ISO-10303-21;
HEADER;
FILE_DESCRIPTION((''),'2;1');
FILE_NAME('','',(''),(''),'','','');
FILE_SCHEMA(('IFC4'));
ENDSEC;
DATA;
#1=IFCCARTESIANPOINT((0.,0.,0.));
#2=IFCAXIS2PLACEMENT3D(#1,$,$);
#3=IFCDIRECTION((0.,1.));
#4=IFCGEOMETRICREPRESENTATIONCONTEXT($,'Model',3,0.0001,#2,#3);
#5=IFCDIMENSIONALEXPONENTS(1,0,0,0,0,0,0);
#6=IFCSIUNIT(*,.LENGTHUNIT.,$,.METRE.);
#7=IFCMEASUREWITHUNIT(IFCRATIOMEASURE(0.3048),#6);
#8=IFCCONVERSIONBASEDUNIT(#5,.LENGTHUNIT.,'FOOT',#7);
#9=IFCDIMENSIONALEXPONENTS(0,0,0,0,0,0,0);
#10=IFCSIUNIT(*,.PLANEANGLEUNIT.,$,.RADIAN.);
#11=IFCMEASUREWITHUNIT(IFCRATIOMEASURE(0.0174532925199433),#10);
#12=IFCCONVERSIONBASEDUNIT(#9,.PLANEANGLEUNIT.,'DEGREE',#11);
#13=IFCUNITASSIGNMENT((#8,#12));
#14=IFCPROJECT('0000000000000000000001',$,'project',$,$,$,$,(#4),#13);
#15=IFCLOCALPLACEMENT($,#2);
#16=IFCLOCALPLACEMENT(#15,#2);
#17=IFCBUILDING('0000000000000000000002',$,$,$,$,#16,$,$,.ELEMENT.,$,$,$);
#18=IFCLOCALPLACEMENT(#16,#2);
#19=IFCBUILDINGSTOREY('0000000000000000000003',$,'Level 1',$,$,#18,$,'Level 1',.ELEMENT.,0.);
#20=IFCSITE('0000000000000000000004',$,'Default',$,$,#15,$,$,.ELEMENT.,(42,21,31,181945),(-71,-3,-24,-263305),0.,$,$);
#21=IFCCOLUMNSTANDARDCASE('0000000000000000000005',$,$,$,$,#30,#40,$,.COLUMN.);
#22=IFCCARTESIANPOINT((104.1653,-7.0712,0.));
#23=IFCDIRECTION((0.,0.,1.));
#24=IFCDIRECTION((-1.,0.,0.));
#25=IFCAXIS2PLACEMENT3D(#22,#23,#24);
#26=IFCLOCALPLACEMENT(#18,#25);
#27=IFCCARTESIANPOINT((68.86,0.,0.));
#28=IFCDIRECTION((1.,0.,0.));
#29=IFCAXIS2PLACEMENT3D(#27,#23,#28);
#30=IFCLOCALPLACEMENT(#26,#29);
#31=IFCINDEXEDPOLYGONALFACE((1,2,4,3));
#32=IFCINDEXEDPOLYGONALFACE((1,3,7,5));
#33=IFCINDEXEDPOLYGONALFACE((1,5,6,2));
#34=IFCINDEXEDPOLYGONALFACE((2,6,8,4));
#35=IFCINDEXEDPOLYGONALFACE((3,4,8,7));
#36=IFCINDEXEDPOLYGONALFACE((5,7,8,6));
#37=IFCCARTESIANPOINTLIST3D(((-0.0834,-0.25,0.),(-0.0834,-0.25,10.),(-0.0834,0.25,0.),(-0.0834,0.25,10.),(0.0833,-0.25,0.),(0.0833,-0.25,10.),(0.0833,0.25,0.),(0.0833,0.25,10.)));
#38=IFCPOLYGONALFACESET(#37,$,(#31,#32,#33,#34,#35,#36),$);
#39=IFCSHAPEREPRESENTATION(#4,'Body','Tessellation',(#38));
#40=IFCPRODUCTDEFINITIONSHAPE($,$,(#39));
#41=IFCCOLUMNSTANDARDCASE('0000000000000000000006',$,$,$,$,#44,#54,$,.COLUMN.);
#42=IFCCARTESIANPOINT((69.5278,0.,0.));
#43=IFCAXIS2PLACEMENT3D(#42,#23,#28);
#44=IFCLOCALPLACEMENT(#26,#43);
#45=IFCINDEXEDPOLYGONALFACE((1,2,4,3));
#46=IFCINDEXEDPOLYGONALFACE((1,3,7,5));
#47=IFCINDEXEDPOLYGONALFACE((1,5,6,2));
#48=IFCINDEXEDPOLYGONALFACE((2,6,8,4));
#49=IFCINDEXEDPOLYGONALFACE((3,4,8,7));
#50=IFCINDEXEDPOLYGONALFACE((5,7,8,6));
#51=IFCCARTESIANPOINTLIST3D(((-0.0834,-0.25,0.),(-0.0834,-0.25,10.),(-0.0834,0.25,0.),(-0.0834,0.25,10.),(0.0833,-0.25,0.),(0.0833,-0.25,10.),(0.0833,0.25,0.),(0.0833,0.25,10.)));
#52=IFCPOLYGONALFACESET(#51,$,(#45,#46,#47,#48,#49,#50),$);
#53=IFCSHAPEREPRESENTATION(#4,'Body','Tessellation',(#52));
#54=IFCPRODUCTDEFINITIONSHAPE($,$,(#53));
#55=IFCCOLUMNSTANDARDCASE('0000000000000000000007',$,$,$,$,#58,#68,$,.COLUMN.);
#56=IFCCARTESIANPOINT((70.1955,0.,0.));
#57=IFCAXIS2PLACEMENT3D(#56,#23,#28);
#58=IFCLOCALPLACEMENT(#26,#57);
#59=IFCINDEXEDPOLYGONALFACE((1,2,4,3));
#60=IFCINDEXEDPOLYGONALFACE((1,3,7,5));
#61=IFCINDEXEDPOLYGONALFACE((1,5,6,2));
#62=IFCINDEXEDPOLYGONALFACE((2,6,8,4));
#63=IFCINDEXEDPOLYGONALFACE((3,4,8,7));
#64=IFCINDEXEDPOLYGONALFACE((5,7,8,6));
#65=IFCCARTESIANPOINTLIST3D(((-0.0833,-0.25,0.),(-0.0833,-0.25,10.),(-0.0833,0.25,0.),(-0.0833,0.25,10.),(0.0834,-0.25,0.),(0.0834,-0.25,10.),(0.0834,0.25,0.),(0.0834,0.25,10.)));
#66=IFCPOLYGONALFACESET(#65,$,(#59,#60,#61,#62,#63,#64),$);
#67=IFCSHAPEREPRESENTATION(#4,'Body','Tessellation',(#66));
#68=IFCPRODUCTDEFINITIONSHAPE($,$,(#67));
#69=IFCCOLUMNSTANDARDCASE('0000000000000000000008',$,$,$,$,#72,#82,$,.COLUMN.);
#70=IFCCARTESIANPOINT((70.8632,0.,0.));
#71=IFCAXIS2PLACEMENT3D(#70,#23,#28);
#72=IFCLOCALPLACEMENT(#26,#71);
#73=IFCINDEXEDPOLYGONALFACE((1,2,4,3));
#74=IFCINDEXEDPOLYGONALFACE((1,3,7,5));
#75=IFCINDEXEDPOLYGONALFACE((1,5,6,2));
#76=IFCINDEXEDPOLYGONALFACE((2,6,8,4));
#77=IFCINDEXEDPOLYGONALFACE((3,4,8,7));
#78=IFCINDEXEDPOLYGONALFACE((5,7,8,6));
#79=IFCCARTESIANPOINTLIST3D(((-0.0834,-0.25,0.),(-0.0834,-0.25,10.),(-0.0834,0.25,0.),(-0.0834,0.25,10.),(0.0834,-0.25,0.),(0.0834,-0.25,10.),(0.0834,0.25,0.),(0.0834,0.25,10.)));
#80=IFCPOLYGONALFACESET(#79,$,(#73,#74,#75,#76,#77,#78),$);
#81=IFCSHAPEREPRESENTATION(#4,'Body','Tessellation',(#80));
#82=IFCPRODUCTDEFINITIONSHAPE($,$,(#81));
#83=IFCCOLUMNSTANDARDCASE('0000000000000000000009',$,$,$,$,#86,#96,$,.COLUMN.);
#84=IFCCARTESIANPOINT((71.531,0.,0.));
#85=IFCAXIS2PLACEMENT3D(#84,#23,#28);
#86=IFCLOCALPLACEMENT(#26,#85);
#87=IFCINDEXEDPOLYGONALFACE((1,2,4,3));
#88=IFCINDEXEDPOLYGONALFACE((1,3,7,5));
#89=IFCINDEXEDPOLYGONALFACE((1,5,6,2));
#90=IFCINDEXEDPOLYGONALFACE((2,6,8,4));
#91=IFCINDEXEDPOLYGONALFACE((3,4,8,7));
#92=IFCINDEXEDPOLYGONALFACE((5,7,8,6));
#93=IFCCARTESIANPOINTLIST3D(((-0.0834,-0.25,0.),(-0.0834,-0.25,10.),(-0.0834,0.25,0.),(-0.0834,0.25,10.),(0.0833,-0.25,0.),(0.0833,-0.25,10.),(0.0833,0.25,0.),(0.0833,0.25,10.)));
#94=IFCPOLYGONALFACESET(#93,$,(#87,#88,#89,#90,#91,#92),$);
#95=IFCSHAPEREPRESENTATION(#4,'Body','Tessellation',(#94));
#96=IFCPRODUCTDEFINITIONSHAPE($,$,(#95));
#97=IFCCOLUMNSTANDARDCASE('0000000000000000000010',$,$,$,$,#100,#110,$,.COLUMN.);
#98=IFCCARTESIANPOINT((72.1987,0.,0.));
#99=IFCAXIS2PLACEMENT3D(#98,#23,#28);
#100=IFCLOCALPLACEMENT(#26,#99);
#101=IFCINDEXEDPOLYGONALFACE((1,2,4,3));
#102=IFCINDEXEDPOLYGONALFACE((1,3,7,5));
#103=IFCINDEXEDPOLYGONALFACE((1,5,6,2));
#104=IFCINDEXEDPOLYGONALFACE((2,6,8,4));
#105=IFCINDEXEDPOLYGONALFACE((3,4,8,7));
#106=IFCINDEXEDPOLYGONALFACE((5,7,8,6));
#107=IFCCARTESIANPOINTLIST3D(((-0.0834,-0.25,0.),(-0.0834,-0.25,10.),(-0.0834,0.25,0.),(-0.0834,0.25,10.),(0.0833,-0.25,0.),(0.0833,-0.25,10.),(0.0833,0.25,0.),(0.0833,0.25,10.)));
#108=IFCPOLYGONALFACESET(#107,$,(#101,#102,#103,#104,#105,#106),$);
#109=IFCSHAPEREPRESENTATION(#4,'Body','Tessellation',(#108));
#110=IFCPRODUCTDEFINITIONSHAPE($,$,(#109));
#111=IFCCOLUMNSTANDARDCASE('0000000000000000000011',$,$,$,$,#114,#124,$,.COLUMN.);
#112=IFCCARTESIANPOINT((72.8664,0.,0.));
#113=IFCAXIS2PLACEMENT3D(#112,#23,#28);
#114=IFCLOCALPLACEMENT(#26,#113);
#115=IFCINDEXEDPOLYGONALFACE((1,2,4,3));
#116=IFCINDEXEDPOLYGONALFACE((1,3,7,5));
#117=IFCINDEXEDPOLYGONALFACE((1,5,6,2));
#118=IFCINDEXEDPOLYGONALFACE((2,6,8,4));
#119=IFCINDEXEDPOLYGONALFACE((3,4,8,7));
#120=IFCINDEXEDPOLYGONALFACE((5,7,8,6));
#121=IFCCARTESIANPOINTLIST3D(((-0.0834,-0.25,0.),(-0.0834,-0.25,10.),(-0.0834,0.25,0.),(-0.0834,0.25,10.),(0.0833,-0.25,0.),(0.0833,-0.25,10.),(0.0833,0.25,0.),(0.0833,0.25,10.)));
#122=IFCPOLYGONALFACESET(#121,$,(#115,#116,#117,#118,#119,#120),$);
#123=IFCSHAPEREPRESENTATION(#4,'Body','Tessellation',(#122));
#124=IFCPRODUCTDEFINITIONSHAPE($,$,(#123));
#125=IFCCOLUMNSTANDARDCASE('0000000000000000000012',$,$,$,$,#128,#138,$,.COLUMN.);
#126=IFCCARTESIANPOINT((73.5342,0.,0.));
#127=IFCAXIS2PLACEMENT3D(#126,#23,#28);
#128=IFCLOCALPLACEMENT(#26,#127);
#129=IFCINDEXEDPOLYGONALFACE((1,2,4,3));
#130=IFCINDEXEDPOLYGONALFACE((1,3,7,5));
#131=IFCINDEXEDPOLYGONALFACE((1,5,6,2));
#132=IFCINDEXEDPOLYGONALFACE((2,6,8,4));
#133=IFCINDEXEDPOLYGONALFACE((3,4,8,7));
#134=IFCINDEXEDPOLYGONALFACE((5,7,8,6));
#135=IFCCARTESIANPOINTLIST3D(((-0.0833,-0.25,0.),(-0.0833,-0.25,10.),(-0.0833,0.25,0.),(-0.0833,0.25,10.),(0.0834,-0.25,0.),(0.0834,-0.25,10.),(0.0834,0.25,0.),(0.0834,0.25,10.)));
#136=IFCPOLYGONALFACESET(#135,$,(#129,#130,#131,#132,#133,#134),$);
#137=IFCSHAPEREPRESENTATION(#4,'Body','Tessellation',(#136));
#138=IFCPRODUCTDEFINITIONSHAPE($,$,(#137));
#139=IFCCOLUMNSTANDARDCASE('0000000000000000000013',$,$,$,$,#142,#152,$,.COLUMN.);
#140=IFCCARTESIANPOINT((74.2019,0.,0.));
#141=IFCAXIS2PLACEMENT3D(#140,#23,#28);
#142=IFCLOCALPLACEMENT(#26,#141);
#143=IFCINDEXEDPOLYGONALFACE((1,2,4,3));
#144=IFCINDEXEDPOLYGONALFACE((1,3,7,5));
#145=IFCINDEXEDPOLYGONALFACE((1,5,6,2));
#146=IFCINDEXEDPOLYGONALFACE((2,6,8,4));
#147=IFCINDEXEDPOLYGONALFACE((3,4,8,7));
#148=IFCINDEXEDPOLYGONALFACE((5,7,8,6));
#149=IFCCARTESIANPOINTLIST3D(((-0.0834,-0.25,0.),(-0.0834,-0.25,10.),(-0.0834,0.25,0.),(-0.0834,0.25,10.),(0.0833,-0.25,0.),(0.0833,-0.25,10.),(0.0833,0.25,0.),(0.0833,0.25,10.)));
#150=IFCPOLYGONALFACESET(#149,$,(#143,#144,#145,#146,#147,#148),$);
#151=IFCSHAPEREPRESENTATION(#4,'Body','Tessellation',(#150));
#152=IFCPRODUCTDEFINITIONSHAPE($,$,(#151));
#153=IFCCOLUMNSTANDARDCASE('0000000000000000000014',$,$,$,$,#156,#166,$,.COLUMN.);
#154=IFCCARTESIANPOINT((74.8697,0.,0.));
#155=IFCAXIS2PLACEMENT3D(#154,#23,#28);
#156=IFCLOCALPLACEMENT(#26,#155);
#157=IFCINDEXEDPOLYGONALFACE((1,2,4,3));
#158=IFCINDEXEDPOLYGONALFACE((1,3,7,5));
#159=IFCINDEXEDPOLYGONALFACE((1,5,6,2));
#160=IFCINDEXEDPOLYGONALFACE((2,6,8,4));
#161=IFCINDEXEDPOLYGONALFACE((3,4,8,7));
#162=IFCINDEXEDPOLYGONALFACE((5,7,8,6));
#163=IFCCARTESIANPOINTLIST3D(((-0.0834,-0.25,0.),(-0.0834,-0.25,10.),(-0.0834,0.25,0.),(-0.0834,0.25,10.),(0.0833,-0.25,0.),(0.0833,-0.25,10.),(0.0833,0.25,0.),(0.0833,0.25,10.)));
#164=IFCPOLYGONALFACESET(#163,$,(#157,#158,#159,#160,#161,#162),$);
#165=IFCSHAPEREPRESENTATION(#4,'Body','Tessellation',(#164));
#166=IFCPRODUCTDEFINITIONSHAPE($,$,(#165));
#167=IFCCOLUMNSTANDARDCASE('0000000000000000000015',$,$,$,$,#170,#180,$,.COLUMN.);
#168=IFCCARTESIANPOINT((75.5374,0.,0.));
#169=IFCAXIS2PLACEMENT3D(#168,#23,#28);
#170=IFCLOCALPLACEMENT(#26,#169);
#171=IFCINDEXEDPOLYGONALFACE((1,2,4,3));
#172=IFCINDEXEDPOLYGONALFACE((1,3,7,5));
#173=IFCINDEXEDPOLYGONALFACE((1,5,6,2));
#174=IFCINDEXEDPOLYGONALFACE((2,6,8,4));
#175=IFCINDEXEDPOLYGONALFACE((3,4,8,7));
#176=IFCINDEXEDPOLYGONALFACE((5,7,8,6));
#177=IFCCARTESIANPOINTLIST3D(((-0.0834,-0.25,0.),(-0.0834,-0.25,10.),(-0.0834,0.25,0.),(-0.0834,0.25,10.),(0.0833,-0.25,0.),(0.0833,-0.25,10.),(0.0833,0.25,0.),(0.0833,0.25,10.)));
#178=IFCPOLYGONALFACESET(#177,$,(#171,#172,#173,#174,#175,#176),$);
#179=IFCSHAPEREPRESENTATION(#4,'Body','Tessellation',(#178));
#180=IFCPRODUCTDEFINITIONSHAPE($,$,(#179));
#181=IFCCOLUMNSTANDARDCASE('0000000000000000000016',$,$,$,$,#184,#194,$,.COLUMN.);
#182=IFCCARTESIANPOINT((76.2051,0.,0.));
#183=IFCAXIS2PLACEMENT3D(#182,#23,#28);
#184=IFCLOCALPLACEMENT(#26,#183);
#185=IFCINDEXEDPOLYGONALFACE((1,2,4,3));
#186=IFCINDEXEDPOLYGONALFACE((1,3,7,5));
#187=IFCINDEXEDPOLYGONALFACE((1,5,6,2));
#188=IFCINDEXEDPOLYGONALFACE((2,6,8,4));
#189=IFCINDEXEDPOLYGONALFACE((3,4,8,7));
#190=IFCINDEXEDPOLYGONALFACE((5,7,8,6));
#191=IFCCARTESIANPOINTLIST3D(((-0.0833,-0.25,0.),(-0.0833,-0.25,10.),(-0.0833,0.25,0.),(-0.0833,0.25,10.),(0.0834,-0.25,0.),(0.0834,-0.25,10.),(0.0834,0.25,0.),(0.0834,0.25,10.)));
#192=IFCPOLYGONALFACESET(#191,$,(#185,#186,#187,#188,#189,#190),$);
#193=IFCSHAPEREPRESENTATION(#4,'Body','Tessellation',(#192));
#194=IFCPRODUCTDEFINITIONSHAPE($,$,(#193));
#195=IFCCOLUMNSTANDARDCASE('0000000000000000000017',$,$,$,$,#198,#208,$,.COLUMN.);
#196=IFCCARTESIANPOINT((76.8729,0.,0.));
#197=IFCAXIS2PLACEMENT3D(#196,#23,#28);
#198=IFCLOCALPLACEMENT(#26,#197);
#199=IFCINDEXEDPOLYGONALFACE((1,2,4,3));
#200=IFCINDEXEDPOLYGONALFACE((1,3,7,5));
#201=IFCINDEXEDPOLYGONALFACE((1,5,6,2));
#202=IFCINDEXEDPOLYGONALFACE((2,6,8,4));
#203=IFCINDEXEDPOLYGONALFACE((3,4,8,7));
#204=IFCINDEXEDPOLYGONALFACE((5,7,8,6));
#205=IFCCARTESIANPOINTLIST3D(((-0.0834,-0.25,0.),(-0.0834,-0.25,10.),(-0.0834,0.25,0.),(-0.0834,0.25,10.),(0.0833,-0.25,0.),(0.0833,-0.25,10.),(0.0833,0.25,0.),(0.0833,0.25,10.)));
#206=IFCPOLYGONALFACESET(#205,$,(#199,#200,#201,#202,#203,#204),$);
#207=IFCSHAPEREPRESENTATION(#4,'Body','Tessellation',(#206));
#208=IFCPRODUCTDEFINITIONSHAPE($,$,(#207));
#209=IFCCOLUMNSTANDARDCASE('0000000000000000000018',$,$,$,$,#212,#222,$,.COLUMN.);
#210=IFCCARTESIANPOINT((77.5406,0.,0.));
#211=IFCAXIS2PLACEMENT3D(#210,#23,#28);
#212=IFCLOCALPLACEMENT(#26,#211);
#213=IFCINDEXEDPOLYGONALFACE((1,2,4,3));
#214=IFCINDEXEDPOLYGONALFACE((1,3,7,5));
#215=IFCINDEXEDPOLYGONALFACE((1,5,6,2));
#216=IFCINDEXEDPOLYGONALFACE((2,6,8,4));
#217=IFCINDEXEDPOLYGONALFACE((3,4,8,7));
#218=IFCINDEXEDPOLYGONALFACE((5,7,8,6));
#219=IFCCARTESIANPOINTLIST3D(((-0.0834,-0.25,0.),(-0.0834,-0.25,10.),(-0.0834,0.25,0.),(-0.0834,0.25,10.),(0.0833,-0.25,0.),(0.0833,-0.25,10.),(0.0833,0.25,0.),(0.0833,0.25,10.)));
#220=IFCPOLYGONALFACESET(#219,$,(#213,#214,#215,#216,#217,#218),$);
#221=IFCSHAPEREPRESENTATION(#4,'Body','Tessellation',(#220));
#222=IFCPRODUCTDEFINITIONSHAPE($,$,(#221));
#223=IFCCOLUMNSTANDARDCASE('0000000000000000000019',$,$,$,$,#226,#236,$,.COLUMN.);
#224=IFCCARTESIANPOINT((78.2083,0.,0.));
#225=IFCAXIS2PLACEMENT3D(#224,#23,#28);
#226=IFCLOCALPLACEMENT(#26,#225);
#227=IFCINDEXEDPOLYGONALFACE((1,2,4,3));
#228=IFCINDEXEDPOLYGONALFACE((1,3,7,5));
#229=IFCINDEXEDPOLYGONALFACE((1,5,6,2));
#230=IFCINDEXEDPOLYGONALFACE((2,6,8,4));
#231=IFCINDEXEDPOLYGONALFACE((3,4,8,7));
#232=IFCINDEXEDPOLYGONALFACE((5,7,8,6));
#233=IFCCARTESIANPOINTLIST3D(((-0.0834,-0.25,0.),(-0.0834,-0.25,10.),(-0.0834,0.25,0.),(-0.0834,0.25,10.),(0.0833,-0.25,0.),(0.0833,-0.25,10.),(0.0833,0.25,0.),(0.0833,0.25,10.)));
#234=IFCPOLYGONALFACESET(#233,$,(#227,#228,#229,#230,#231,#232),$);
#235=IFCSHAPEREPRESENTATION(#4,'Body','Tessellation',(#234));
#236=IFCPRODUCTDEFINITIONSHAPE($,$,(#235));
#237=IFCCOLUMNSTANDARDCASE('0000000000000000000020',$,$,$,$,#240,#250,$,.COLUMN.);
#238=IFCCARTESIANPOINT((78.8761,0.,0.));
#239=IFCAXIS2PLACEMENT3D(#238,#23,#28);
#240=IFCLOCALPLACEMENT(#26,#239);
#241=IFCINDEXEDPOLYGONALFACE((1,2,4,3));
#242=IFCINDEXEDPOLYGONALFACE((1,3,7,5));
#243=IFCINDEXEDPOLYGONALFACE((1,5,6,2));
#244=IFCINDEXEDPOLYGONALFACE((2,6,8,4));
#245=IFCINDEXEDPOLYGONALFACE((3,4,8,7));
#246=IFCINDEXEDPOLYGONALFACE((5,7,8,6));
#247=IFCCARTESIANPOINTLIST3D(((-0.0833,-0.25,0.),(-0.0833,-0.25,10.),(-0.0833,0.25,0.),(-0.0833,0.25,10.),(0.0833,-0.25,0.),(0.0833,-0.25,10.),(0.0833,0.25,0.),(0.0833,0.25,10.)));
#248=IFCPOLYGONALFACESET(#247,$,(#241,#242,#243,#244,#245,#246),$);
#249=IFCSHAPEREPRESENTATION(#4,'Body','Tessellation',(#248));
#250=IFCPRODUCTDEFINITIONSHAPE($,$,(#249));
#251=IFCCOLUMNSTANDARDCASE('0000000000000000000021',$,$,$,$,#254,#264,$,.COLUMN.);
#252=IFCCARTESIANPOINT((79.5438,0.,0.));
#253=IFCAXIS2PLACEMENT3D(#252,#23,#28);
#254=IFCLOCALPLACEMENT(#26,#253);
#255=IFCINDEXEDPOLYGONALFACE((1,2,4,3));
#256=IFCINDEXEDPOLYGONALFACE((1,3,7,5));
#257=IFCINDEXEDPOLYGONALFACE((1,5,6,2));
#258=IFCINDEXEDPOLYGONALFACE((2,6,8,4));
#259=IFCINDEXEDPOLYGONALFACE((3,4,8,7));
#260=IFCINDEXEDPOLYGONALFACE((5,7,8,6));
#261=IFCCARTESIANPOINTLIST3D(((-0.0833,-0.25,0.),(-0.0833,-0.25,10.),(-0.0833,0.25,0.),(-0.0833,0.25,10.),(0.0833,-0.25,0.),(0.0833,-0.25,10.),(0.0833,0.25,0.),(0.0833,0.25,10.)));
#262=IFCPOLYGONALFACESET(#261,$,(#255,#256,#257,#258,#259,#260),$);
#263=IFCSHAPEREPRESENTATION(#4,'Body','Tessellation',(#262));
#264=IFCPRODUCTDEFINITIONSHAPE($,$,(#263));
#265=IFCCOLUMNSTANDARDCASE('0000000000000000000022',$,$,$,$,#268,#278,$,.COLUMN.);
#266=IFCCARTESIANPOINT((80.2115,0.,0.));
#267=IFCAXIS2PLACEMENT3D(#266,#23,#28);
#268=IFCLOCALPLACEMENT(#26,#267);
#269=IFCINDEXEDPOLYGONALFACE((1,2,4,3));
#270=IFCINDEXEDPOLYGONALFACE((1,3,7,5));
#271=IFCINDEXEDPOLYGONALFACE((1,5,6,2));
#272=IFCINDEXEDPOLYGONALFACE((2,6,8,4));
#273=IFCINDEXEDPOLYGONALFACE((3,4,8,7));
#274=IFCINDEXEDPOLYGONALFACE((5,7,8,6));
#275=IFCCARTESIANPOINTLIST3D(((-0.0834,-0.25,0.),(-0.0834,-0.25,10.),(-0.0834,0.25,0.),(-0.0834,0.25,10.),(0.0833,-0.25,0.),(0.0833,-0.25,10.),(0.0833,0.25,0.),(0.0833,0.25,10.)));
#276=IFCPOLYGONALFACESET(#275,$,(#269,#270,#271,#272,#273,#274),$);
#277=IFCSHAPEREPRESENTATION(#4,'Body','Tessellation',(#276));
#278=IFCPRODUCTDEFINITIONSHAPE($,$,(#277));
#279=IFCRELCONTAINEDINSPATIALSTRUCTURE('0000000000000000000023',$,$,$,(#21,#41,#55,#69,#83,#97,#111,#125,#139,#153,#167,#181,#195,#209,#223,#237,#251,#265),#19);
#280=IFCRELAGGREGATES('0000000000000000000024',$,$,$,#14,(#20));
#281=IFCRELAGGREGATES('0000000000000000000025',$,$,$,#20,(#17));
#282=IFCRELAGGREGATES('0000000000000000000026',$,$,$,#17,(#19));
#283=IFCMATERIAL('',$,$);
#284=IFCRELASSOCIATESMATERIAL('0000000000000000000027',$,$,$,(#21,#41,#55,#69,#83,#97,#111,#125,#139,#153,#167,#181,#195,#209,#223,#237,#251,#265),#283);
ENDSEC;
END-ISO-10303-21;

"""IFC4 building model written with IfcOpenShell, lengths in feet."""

from ifc_helpers import new_model, entity, si_unit, converted_unit, direction, frame, origin, place, context, project, spatial, rectangle, extrude, material, element, save


model = new_model("IFC4")

# Units and contexts
model_context = context("Model", 3, precision=0.0001, world=origin(), true_north=direction((0.0, 1.0)))
ifc_project = project(units=[converted_unit("LENGTHUNIT", "FOOT", entity("IfcRatioMeasure", 0.3048), si_unit("LENGTHUNIT", "METRE"), dimensions=[1, 0, 0, 0, 0, 0, 0]), converted_unit("PLANEANGLEUNIT", "DEGREE", entity("IfcRatioMeasure", 0.0174532925199433), si_unit("PLANEANGLEUNIT", "RADIAN"), dimensions=[0, 0, 0, 0, 0, 0, 0])], contexts=[model_context])

# Site, building, storey
site_placement = place(None, origin())
site = spatial("IfcSite", under=ifc_project, at=site_placement, Name="Default", CompositionType="ELEMENT", RefLatitude=(42, 21, 31, 181945), RefLongitude=(-71, -3, -24, -263305), RefElevation=0.0)
building_placement = place(site_placement, origin())
building = spatial("IfcBuilding", under=site, at=building_placement, CompositionType="ELEMENT")
storey_placement = place(building_placement, origin())
storey = spatial("IfcBuildingStorey", under=building, at=storey_placement, Name="Level 1", LongName="Level 1", CompositionType="ELEMENT", Elevation=0.0)

# Columns
ifc_material_1 = material(Name="")
placement = place(storey_placement, frame((104.1653, -7.0712, 0.0), z_axis=(0.0, 0.0, 1.0), x_axis=(-1.0, 0.0, 0.0)))
for number, where, z_axis, x_axis in (
    (1, (68.86, 0.0, 0.0), (0.0, 0.0, 1.0), (1.0, 0.0, 0.0)),
    (2, (69.5278, 0.0, 0.0), (0.0, 0.0, 1.0), (1.0, 0.0, 0.0)),
    (3, (70.1955, 0.0, 0.0), (0.0, 0.0, 1.0), (1.0, 0.0, 0.0)),
    (4, (70.8632, 0.0, 0.0), (0.0, 0.0, 1.0), (1.0, 0.0, 0.0)),
    (5, (71.531, 0.0, 0.0), (0.0, 0.0, 1.0), (1.0, 0.0, 0.0)),
    (6, (72.1987, 0.0, 0.0), (0.0, 0.0, 1.0), (1.0, 0.0, 0.0)),
    (7, (72.8664, 0.0, 0.0), (0.0, 0.0, 1.0), (1.0, 0.0, 0.0)),
    (8, (73.5342, 0.0, 0.0), (0.0, 0.0, 1.0), (1.0, 0.0, 0.0)),
    (9, (74.2019, 0.0, 0.0), (0.0, 0.0, 1.0), (1.0, 0.0, 0.0)),
    (10, (74.8697, 0.0, 0.0), (0.0, 0.0, 1.0), (1.0, 0.0, 0.0)),
    (11, (75.5374, 0.0, 0.0), (0.0, 0.0, 1.0), (1.0, 0.0, 0.0)),
    (12, (76.2051, 0.0, 0.0), (0.0, 0.0, 1.0), (1.0, 0.0, 0.0)),
    (13, (76.8729, 0.0, 0.0), (0.0, 0.0, 1.0), (1.0, 0.0, 0.0)),
    (14, (77.5406, 0.0, 0.0), (0.0, 0.0, 1.0), (1.0, 0.0, 0.0)),
    (15, (78.2083, 0.0, 0.0), (0.0, 0.0, 1.0), (1.0, 0.0, 0.0)),
    (16, (78.8761, 0.0, 0.0), (0.0, 0.0, 1.0), (1.0, 0.0, 0.0)),
    (17, (79.5438, 0.0, 0.0), (0.0, 0.0, 1.0), (1.0, 0.0, 0.0)),
    (18, (80.2115, 0.0, 0.0), (0.0, 0.0, 1.0), (1.0, 0.0, 0.0)),
):
    element("IfcColumnStandardCase", number, at=place(placement, frame(where, z_axis=z_axis, x_axis=x_axis)), inside=storey, material=ifc_material_1, PredefinedType="COLUMN", context=model_context, shape_type="SweptSolid", body=[
        extrude(rectangle(XDim=0.1667, YDim=0.5), origin(), (0.0, 0.0, 1.0), 10.0),
    ])

save(model, "model.ifc")
